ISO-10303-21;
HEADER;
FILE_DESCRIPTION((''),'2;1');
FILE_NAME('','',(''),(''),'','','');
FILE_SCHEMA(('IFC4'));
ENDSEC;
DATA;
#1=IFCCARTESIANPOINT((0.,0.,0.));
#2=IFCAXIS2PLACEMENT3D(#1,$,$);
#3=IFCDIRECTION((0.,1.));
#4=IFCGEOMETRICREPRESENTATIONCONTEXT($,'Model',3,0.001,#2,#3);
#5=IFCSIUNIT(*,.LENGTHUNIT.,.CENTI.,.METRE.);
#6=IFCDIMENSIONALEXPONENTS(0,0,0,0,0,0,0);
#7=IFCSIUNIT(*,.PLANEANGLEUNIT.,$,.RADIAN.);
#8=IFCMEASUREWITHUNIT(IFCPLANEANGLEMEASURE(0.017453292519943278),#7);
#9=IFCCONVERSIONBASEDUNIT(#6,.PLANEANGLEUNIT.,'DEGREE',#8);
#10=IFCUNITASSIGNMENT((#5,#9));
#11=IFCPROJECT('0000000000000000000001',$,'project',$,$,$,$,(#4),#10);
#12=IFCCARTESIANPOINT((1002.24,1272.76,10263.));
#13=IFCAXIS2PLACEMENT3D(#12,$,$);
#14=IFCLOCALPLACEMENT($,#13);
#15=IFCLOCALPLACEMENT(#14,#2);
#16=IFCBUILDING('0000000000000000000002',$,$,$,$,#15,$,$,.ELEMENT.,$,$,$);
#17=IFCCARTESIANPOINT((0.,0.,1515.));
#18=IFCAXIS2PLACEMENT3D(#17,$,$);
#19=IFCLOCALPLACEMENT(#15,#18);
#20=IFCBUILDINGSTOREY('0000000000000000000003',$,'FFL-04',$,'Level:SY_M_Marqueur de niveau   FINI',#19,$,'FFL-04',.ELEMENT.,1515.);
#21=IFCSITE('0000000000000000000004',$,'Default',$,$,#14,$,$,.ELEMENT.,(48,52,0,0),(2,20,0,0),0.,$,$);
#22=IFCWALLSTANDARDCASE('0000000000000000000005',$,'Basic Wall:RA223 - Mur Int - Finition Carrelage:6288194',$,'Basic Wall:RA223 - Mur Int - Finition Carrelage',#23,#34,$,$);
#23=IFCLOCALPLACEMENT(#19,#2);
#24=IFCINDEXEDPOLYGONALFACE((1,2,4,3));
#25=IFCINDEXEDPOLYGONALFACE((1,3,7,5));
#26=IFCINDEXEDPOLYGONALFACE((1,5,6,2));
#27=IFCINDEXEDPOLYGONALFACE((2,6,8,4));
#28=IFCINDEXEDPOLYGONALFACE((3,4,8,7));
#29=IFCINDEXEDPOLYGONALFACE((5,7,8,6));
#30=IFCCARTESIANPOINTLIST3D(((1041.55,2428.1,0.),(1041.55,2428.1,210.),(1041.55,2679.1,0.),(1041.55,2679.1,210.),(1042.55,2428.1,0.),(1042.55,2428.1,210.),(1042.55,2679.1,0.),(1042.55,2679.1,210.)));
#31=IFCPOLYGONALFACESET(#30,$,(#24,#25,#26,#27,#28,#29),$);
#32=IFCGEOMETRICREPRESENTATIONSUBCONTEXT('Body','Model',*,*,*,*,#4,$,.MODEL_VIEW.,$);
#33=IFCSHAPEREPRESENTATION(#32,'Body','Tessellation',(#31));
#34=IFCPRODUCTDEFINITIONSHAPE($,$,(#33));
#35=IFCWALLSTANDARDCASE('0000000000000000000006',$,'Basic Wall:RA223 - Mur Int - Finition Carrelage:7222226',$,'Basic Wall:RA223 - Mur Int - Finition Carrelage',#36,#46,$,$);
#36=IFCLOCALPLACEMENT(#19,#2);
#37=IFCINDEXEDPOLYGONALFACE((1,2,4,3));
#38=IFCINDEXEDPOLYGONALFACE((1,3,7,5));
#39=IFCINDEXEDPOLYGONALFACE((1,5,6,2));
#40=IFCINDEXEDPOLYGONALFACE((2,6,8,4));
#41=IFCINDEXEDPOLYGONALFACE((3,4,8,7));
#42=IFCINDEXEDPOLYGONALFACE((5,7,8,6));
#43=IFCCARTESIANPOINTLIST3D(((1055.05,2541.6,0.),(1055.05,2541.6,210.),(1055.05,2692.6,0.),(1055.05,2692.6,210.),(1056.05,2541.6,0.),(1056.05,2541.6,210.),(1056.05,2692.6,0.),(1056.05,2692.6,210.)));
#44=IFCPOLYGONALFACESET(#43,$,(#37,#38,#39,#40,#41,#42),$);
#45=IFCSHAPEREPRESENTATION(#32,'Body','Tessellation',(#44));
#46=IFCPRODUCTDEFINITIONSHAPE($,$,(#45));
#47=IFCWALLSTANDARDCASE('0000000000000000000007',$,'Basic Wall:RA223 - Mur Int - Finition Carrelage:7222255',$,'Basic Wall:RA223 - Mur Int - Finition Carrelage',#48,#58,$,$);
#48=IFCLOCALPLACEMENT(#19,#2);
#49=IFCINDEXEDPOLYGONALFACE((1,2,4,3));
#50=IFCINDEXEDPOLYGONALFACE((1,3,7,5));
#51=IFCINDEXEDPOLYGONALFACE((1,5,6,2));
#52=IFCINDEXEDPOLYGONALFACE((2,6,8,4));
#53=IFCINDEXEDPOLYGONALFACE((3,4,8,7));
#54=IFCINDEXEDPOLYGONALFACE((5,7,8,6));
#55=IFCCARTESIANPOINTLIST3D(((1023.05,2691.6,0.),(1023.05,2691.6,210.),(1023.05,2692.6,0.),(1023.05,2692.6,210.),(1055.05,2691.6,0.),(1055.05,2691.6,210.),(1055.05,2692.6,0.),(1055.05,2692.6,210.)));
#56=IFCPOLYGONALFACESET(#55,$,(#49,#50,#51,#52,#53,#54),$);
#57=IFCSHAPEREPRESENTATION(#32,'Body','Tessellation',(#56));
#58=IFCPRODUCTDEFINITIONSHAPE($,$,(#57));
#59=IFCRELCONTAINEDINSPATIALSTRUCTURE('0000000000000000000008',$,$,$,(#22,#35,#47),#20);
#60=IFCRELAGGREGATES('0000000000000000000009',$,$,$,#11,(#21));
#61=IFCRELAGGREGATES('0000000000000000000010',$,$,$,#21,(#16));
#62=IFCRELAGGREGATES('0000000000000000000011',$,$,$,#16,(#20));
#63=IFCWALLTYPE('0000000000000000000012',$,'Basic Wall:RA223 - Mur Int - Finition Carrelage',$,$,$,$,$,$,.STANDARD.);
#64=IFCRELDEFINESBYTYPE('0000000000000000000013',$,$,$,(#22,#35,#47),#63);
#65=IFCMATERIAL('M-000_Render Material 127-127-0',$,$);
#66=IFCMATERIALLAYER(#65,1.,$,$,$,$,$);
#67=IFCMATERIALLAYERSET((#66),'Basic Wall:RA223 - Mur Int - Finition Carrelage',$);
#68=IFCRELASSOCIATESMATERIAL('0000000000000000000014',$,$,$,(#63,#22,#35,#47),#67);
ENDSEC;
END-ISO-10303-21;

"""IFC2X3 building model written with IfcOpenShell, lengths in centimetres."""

from ifc_helpers import new_model, entity, si_unit, converted_unit, direction, frame, frame_2d, origin, place, context, subcontext, project, spatial, rectangle, extrude, material, layer, layer_set, layer_usage, type_object, element, save


model = new_model("IFC2X3")

# Units and contexts
model_context = context("Model", 3, precision=0.001, world=origin(), true_north=direction((0.0, 1.0)))
body_context = subcontext(model_context, "Body", "Model", "MODEL_VIEW")
ifc_project = project(units=[si_unit("LENGTHUNIT", "METRE", prefix="CENTI"), converted_unit("PLANEANGLEUNIT", "DEGREE", entity("IfcPlaneAngleMeasure", 0.017453292519943278), si_unit("PLANEANGLEUNIT", "RADIAN"), dimensions=[0, 0, 0, 0, 0, 0, 0])], contexts=[model_context])

# Site, building, storey
site_placement = place(None, frame((1002.24, 1272.76, 10263.0)))
site = spatial("IfcSite", under=ifc_project, at=site_placement, Name="Default", CompositionType="ELEMENT", RefLatitude=(48, 52, 0, 0), RefLongitude=(2, 20, 0, 0), RefElevation=0.0)
building_placement = place(site_placement, origin())
building = spatial("IfcBuilding", under=site, at=building_placement, CompositionType="ELEMENT")
storey_placement = place(building_placement, frame((0.0, 0.0, 1515.0)))
storey = spatial("IfcBuildingStorey", under=building, at=storey_placement, Name="FFL-04", ObjectType="Level:SY_M_Marqueur de niveau   FINI", LongName="FFL-04", CompositionType="ELEMENT", Elevation=1515.0)

# Shared definitions
ifc_material_1 = material(Name="M-000_Render Material 127-127-0")
ifc_layer_1 = layer(ifc_material_1, 1.0)
ifc_layer_set_1 = layer_set([ifc_layer_1], Name="Basic Wall:RA223 - Mur Int - Finition Carrelage")
wall_type_1 = type_object("IfcWallType", Name="Basic Wall:RA223 - Mur Int - Finition Carrelage", PredefinedType="STANDARD", material=ifc_layer_set_1)

# Walls
ifc_layer_usage_1 = layer_usage(ifc_layer_set_1, "AXIS2", "POSITIVE", -0.5)
wall_1_placement = place(storey_placement, frame((1042.05, 2679.1, 0.0), z_axis=(0.0, 0.0, 1.0), x_axis=(0.0, -1.0, 0.0)))
element("IfcWallStandardCase", 1, at=wall_1_placement, inside=storey, type_object=wall_type_1, material=ifc_layer_usage_1, Name="Basic Wall:RA223 - Mur Int - Finition Carrelage:6288194", ObjectType="Basic Wall:RA223 - Mur Int - Finition Carrelage", context=body_context, shape_type="SweptSolid", body=[
    extrude(rectangle(XDim=251.0, YDim=1.0, at=frame_2d((125.5, 0.0), x_axis=(-1.0, 0.0))), origin(), (0.0, 0.0, 1.0), 210.0),
])
ifc_layer_usage_2 = layer_usage(ifc_layer_set_1, "AXIS2", "NEGATIVE", 0.5)
wall_2_placement = place(storey_placement, frame((1055.55, 2692.6, 0.0), z_axis=(0.0, 0.0, 1.0), x_axis=(0.0, -1.0, 0.0)))
element("IfcWallStandardCase", 2, at=wall_2_placement, inside=storey, type_object=wall_type_1, material=ifc_layer_usage_2, Name="Basic Wall:RA223 - Mur Int - Finition Carrelage:7222226", ObjectType="Basic Wall:RA223 - Mur Int - Finition Carrelage", context=body_context, shape_type="SweptSolid", body=[
    extrude(rectangle(XDim=151.0, YDim=1.0, at=frame_2d((75.5, 0.0), x_axis=(-1.0, 0.0))), origin(), (0.0, 0.0, 1.0), 210.0),
])
ifc_layer_usage_3 = layer_usage(ifc_layer_set_1, "AXIS2", "NEGATIVE", 0.5)
wall_3_placement = place(storey_placement, frame((1023.05, 2692.1, 0.0)))
element("IfcWallStandardCase", 3, at=wall_3_placement, inside=storey, type_object=wall_type_1, material=ifc_layer_usage_3, Name="Basic Wall:RA223 - Mur Int - Finition Carrelage:7222255", ObjectType="Basic Wall:RA223 - Mur Int - Finition Carrelage", context=body_context, shape_type="SweptSolid", body=[
    extrude(rectangle(XDim=32.0, YDim=1.0, at=frame_2d((16.0, 0.0), x_axis=(-1.0, 0.0))), origin(), (0.0, 0.0, 1.0), 210.0),
])

save(model, "model.ifc")
